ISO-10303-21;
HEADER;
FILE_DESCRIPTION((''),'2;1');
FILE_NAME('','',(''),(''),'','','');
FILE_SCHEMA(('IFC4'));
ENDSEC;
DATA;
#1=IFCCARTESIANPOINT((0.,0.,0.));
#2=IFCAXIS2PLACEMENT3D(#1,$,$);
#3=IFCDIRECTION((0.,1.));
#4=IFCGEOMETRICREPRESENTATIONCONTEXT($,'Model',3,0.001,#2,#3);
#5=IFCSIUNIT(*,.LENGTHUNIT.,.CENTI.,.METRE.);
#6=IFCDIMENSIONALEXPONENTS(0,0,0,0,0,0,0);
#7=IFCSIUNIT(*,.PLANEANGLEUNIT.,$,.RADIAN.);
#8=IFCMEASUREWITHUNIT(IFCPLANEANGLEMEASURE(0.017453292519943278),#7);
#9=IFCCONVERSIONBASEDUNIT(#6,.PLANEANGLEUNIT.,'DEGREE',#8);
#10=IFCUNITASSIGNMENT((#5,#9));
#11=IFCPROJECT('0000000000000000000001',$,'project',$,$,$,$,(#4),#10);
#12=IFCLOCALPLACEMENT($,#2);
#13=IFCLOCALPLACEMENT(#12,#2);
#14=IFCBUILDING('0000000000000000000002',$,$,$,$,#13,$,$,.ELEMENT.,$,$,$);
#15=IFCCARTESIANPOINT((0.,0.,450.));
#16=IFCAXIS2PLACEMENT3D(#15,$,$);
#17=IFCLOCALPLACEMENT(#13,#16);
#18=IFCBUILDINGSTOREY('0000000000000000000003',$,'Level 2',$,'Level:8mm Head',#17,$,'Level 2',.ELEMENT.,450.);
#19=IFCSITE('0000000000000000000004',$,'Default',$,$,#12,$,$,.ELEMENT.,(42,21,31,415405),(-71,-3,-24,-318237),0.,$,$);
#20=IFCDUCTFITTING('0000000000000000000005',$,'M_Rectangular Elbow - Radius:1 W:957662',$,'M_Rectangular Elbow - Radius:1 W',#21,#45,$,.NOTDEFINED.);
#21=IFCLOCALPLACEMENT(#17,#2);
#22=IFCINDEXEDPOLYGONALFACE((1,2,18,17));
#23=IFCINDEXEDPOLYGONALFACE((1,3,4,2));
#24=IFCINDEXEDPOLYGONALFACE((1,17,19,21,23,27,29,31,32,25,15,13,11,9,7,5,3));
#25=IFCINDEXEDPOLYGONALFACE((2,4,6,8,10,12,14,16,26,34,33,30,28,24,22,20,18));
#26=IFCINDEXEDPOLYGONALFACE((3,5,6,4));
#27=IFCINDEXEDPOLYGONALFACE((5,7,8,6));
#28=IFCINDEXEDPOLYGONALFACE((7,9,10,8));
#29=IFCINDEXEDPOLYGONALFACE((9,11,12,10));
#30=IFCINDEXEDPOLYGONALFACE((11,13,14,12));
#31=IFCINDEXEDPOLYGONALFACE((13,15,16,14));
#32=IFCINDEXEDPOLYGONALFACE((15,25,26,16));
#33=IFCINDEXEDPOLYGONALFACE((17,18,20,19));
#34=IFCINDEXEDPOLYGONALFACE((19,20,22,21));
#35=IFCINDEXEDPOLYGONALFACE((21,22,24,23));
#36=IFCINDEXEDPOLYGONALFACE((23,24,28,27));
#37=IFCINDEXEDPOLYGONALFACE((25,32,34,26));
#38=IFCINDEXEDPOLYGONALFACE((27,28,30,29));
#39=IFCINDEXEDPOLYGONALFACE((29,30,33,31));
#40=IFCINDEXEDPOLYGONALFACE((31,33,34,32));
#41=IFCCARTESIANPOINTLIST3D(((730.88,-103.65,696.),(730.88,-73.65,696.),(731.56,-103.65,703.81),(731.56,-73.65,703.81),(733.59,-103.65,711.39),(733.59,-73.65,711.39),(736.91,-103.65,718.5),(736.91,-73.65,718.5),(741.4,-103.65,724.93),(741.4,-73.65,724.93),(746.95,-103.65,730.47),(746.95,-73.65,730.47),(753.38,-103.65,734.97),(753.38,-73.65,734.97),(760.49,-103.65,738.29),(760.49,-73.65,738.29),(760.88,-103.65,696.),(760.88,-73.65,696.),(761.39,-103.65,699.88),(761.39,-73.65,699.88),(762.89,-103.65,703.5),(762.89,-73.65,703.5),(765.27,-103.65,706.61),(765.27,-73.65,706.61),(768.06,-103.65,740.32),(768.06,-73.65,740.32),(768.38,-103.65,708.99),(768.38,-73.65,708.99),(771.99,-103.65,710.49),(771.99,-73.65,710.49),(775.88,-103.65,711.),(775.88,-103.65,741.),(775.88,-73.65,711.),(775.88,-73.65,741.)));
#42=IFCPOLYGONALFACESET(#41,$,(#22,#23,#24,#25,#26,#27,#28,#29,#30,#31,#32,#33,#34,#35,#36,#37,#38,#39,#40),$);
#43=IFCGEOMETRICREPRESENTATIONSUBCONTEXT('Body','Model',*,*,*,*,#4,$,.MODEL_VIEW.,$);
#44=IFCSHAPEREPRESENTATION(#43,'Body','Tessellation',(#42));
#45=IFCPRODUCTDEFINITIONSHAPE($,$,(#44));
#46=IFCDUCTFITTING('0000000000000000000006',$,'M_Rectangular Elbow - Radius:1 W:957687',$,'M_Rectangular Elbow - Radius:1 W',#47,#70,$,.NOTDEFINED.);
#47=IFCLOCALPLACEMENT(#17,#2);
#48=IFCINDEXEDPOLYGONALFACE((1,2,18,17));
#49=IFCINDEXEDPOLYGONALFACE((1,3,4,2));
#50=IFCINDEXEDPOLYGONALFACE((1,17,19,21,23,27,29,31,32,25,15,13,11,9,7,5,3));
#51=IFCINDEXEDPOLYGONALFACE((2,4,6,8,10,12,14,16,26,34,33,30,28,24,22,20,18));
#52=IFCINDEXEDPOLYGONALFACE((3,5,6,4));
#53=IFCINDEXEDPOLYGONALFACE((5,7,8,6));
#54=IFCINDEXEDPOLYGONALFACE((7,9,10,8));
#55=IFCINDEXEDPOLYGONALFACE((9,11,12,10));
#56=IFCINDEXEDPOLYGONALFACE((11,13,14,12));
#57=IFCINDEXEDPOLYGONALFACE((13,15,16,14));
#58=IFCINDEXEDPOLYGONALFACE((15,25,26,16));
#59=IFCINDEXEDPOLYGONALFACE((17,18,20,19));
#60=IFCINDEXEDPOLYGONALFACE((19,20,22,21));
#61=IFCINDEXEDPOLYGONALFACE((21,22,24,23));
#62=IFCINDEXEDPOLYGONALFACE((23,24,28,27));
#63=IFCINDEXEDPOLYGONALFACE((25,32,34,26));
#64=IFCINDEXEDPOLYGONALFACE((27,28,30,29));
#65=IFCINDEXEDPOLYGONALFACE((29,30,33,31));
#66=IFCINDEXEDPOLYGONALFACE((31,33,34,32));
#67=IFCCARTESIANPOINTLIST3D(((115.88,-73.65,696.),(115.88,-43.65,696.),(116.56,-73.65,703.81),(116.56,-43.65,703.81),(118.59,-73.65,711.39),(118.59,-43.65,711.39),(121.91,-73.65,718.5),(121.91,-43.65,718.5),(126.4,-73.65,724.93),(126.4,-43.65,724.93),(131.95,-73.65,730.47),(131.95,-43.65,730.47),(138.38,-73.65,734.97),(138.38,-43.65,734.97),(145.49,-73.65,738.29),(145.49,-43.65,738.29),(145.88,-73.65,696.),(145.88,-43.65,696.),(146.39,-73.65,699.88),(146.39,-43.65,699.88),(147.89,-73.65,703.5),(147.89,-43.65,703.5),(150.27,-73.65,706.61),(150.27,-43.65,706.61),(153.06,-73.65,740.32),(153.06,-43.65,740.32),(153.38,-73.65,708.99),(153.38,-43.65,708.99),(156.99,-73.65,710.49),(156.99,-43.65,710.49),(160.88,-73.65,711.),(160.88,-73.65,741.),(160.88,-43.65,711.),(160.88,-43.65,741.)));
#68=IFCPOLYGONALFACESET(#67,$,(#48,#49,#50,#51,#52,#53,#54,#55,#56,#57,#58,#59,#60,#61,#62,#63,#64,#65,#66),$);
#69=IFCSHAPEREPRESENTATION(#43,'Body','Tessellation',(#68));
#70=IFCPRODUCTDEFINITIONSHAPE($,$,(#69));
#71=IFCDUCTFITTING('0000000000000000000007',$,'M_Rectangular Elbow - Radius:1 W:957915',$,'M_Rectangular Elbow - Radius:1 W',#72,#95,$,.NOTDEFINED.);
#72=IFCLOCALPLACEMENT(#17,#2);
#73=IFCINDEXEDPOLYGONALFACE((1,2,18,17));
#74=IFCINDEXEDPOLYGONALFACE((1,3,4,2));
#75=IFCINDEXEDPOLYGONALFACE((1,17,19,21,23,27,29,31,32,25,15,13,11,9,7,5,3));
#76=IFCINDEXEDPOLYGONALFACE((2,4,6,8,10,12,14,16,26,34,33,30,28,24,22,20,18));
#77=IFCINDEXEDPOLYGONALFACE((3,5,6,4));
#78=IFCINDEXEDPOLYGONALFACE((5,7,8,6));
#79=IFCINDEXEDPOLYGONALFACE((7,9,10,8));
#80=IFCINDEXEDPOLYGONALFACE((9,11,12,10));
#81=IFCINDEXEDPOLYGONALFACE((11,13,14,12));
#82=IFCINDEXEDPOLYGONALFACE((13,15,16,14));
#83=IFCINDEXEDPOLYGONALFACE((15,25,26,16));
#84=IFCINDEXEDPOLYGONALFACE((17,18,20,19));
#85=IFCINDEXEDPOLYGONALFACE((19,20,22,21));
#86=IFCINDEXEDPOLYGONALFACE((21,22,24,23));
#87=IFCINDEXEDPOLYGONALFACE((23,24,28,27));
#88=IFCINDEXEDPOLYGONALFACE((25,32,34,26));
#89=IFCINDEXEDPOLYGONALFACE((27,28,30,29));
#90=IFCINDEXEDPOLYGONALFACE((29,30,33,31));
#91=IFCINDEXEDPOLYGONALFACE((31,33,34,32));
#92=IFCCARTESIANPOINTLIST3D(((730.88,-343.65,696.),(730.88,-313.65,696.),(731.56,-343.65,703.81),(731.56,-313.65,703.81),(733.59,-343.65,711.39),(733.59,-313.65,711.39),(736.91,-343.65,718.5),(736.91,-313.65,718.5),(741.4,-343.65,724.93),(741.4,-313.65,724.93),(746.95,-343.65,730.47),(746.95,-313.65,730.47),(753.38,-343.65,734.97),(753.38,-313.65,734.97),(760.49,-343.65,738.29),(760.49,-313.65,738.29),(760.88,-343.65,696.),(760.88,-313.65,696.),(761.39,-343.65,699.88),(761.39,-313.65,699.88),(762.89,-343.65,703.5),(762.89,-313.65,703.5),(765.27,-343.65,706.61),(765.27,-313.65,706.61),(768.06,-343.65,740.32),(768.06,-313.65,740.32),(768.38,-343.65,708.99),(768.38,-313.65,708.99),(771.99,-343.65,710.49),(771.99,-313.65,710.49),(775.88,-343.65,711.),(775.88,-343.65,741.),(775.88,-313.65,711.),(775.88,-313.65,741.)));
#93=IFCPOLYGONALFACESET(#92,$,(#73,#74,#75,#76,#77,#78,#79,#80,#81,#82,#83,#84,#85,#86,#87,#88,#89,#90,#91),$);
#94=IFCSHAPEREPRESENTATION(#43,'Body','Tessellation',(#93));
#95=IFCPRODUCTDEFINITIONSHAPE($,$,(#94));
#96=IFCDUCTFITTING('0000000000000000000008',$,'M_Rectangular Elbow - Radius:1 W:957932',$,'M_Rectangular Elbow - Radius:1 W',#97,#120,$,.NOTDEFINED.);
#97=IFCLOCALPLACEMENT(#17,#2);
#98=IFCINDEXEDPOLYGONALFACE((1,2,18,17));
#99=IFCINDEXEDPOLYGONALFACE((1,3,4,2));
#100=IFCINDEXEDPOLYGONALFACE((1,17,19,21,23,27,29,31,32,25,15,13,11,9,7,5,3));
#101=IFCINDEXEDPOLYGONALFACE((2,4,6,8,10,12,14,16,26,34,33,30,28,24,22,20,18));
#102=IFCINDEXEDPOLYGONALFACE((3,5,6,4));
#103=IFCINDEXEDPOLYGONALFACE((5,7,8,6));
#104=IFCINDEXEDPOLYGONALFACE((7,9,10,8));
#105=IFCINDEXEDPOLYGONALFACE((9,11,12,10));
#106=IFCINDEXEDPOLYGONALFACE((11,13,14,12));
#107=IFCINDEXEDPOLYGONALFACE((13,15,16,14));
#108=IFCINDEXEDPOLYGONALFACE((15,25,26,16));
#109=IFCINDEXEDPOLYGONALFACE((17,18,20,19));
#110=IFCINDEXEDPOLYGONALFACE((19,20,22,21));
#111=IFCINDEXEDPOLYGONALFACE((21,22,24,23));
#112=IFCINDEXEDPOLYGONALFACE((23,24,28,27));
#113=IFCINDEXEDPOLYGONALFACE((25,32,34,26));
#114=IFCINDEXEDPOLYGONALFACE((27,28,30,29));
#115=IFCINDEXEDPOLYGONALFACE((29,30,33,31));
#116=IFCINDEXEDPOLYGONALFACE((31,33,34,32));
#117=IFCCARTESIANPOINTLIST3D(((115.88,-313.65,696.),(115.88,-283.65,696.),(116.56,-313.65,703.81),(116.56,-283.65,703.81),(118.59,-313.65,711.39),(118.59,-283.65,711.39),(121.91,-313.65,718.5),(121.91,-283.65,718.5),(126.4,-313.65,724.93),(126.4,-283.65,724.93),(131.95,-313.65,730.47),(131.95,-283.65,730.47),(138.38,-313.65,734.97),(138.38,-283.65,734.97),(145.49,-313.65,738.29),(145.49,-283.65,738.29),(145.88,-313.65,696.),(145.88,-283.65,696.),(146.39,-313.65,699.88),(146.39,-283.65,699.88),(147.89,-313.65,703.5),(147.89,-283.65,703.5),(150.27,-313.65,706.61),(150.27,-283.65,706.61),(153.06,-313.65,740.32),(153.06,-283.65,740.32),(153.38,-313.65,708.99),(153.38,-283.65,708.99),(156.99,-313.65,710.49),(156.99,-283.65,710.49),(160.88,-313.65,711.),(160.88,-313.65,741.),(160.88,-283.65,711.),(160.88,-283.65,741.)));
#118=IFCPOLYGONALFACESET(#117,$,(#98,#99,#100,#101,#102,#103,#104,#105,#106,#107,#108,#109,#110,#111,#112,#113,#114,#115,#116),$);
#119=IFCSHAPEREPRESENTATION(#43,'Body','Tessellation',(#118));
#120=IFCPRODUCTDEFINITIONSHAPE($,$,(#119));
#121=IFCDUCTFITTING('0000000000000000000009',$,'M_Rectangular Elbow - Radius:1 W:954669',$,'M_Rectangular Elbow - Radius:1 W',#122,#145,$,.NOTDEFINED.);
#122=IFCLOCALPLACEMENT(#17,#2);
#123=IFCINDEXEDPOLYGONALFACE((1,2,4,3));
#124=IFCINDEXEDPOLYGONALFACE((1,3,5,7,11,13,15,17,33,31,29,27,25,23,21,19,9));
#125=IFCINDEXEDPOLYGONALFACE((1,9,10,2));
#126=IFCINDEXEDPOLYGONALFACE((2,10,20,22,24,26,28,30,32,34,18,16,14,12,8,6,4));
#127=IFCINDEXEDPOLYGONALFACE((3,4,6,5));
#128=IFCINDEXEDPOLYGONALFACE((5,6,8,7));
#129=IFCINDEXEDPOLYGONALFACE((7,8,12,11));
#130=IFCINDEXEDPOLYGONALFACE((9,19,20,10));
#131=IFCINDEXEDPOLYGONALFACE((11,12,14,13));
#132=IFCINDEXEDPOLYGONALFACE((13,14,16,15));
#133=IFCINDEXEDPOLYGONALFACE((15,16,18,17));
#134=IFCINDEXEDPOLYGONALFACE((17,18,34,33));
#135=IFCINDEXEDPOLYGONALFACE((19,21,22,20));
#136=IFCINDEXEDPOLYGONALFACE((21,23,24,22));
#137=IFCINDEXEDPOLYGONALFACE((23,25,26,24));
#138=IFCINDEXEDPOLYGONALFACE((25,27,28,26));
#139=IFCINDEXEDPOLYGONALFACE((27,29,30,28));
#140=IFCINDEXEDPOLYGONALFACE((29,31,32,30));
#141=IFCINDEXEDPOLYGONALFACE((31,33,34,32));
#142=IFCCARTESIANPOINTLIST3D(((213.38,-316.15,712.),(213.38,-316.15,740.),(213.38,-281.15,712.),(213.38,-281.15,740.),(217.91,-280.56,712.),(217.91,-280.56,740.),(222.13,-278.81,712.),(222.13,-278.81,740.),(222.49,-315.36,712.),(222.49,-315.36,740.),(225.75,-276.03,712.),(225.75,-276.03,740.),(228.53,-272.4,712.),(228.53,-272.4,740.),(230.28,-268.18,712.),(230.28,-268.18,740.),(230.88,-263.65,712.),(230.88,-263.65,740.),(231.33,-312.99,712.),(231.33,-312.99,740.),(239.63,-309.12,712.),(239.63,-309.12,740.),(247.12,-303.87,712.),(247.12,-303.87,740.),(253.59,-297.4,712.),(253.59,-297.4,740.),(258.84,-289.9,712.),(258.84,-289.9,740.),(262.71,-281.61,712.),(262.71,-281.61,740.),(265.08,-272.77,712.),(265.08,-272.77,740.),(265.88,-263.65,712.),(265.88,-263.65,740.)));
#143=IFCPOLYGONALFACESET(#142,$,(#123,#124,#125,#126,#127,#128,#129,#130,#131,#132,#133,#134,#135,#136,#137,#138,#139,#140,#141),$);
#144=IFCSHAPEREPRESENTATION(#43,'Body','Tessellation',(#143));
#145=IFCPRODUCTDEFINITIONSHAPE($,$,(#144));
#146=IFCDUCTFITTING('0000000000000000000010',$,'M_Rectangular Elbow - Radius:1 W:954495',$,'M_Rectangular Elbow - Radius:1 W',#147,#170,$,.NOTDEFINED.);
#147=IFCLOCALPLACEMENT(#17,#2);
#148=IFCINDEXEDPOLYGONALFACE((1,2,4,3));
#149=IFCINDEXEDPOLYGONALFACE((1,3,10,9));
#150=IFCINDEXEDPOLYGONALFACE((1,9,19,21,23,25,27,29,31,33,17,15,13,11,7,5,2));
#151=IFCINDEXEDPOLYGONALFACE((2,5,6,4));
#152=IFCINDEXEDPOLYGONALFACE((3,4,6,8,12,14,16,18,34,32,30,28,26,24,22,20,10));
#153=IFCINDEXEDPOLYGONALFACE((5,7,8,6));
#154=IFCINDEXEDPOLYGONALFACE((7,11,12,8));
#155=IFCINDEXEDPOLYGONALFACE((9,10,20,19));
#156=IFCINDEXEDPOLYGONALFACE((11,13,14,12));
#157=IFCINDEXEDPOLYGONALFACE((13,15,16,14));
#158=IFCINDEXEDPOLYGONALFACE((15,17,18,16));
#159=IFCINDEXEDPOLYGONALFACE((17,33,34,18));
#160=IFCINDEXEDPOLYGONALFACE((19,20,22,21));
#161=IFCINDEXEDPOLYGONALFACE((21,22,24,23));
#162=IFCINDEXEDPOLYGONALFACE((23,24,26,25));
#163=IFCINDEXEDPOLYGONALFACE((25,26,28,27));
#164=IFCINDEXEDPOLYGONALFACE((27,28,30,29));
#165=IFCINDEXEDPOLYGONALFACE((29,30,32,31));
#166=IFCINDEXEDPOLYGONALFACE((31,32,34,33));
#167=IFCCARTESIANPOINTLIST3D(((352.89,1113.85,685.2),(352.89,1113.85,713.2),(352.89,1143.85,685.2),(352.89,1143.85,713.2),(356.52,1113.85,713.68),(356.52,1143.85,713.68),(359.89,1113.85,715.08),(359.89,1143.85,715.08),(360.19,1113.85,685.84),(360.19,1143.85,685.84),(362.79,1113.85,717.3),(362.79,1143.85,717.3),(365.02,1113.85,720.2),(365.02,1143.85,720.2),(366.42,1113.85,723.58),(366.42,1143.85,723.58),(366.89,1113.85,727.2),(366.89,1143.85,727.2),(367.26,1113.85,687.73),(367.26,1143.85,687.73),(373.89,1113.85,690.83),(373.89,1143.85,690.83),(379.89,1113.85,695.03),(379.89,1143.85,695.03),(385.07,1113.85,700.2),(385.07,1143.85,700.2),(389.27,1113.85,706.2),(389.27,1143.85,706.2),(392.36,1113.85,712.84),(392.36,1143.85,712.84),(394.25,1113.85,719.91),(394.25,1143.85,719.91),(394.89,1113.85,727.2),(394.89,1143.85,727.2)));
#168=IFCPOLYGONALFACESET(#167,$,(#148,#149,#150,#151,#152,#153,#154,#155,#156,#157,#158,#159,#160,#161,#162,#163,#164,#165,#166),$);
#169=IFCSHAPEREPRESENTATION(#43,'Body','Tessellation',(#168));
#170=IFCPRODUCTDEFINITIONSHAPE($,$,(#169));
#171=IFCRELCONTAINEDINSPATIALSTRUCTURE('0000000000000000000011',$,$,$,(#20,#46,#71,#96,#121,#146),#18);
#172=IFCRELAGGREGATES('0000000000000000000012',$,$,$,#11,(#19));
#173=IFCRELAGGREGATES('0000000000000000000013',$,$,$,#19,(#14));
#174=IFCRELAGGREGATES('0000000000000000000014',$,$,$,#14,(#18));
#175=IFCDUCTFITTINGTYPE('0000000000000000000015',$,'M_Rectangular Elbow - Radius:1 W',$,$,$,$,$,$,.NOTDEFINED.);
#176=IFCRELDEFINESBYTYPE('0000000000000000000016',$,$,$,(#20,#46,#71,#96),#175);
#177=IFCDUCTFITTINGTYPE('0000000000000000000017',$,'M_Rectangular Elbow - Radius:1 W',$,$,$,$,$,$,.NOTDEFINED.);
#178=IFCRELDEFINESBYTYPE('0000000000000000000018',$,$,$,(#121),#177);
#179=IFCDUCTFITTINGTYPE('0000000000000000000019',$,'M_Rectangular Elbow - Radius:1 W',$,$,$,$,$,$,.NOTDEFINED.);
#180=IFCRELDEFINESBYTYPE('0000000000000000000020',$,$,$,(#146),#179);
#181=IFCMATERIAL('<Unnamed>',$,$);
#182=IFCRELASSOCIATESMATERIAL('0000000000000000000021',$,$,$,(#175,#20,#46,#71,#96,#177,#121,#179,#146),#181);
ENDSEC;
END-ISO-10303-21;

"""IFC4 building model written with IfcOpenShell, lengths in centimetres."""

from ifc_helpers import new_model, entity, si_unit, converted_unit, direction, frame, origin, place, context, subcontext, project, spatial, line, arc, indexed_curve, outline, extrude, source, transform, mapped, material, type_object, type_shapes, element, save


model = new_model("IFC4")

# Units and contexts
model_context = context("Model", 3, precision=0.001, world=origin(), true_north=direction((0.0, 1.0)))
body_context = subcontext(model_context, "Body", "Model", "MODEL_VIEW")
ifc_project = project(units=[si_unit("LENGTHUNIT", "METRE", prefix="CENTI"), converted_unit("PLANEANGLEUNIT", "DEGREE", entity("IfcPlaneAngleMeasure", 0.017453292519943278), si_unit("PLANEANGLEUNIT", "RADIAN"), dimensions=[0, 0, 0, 0, 0, 0, 0])], contexts=[model_context])

# Site, building, storey
site_placement = place(None, origin())
site = spatial("IfcSite", under=ifc_project, at=site_placement, Name="Default", CompositionType="ELEMENT", RefLatitude=(42, 21, 31, 415405), RefLongitude=(-71, -3, -24, -318237), RefElevation=0.0)
building_placement = place(site_placement, origin())
building = spatial("IfcBuilding", under=site, at=building_placement, CompositionType="ELEMENT")
storey_placement = place(building_placement, frame((0.0, 0.0, 450.0)))
storey = spatial("IfcBuildingStorey", under=building, at=storey_placement, Name="Level 2", ObjectType="Level:8mm Head", LongName="Level 2", CompositionType="ELEMENT", Elevation=450.0)

# Duct fittings
ifc_material = material(Name="<Unnamed>")
duct_fitting_type_1 = type_object("IfcDuctFittingType", Name="M_Rectangular Elbow - Radius:1 W", PredefinedType="NOTDEFINED", material=ifc_material)
shared_shape_1 = source(origin(), body_context, "Body", "SweptSolid", [
    extrude(outline(indexed_curve([(-30.0, -15.0), (0.0, -15.0), (4.39, -4.39), (15.0, 0.0), (15.0, 30.0), (-16.82, 16.82)], segments=[line(1, 2), arc(2, 3, 4), line(4, 5), arc(5, 6, 1)], self_intersect=False)), frame((-15.0, 15.0, -15.0), z_axis=(0.0, 0.0, 1.0), x_axis=(-1.0, 0.0, 0.0)), (0.0, 0.0, 1.0), 30.0),
])
type_shapes(duct_fitting_type_1, [shared_shape_1])
for number, where, z_axis, x_axis, name in (
    (1, (745.88, -88.65, 726.0), (0.0, -1.0, 0.0), (-1.0, 0.0, 0.0), "M_Rectangular Elbow - Radius:1 W:957662"),
    (2, (130.88, -58.65, 726.0), (0.0, -1.0, 0.0), (-1.0, 0.0, 0.0), "M_Rectangular Elbow - Radius:1 W:957687"),
    (3, (745.88, -328.65, 726.0), (0.0, -1.0, 0.0), (-1.0, 0.0, 0.0), "M_Rectangular Elbow - Radius:1 W:957915"),
    (4, (130.88, -298.65, 726.0), (0.0, -1.0, 0.0), (-1.0, 0.0, 0.0), "M_Rectangular Elbow - Radius:1 W:957932"),
):
    element("IfcDuctFitting", number, at=place(storey_placement, frame(where, z_axis=z_axis, x_axis=x_axis)), inside=storey, type_object=duct_fitting_type_1, material=ifc_material, Name=name, ObjectType="M_Rectangular Elbow - Radius:1 W", PredefinedType="NOTDEFINED", context=body_context, shape_type="MappedRepresentation", body=[
        mapped(shared_shape_1, transform((0.0, 0.0, 0.0), scale=1.0)),
    ])
duct_fitting_type_2 = type_object("IfcDuctFittingType", Name="M_Rectangular Elbow - Radius:1 W", PredefinedType="NOTDEFINED", material=ifc_material)
shared_shape_2 = source(origin(), body_context, "Body", "SweptSolid", [
    extrude(outline(indexed_curve([(-35.0, -17.5), (0.0, -17.5), (5.13, -5.13), (17.5, 0.0), (17.5, 35.0), (-19.62, 19.62)], segments=[line(1, 2), arc(2, 3, 4), line(4, 5), arc(5, 6, 1)], self_intersect=False)), frame((-17.5, 17.5, -14.0), z_axis=(0.0, 0.0, 1.0), x_axis=(-1.0, 0.0, 0.0)), (0.0, 0.0, 1.0), 28.0),
])
type_shapes(duct_fitting_type_2, [shared_shape_2])
duct_fitting_1_placement = place(storey_placement, frame((248.38, -298.65, 726.0)))
element("IfcDuctFitting", 5, at=duct_fitting_1_placement, inside=storey, type_object=duct_fitting_type_2, material=ifc_material, Name="M_Rectangular Elbow - Radius:1 W:954669", ObjectType="M_Rectangular Elbow - Radius:1 W", PredefinedType="NOTDEFINED", context=body_context, shape_type="MappedRepresentation", body=[
    mapped(shared_shape_2, transform((0.0, 0.0, 0.0), scale=1.0)),
])
duct_fitting_type_3 = type_object("IfcDuctFittingType", Name="M_Rectangular Elbow - Radius:1 W", PredefinedType="NOTDEFINED", material=ifc_material)
shared_shape_3 = source(origin(), body_context, "Body", "SweptSolid", [
    extrude(outline(indexed_curve([(-14.0, -28.0), (15.7, -15.7), (28.0, 14.0), (0.0, 14.0), (-4.1, 4.1), (-14.0, 0.0)], segments=[arc(1, 2, 3), line(3, 4), arc(4, 5, 6), line(6, 1)], self_intersect=False)), frame((-14.0, -14.0, -15.0), z_axis=(0.0, 0.0, 1.0), x_axis=(0.0, 1.0, 0.0)), (0.0, 0.0, 1.0), 30.0),
])
type_shapes(duct_fitting_type_3, [shared_shape_3])
duct_fitting_2_placement = place(storey_placement, frame((380.89, 1128.85, 699.2), z_axis=(0.0, -1.0, 0.0), x_axis=(0.0, 0.0, -1.0)))
element("IfcDuctFitting", 6, at=duct_fitting_2_placement, inside=storey, type_object=duct_fitting_type_3, material=ifc_material, Name="M_Rectangular Elbow - Radius:1 W:954495", ObjectType="M_Rectangular Elbow - Radius:1 W", PredefinedType="NOTDEFINED", context=body_context, shape_type="MappedRepresentation", body=[
    mapped(shared_shape_3, transform((0.0, 0.0, 0.0), scale=1.0)),
])

save(model, "model.ifc")
